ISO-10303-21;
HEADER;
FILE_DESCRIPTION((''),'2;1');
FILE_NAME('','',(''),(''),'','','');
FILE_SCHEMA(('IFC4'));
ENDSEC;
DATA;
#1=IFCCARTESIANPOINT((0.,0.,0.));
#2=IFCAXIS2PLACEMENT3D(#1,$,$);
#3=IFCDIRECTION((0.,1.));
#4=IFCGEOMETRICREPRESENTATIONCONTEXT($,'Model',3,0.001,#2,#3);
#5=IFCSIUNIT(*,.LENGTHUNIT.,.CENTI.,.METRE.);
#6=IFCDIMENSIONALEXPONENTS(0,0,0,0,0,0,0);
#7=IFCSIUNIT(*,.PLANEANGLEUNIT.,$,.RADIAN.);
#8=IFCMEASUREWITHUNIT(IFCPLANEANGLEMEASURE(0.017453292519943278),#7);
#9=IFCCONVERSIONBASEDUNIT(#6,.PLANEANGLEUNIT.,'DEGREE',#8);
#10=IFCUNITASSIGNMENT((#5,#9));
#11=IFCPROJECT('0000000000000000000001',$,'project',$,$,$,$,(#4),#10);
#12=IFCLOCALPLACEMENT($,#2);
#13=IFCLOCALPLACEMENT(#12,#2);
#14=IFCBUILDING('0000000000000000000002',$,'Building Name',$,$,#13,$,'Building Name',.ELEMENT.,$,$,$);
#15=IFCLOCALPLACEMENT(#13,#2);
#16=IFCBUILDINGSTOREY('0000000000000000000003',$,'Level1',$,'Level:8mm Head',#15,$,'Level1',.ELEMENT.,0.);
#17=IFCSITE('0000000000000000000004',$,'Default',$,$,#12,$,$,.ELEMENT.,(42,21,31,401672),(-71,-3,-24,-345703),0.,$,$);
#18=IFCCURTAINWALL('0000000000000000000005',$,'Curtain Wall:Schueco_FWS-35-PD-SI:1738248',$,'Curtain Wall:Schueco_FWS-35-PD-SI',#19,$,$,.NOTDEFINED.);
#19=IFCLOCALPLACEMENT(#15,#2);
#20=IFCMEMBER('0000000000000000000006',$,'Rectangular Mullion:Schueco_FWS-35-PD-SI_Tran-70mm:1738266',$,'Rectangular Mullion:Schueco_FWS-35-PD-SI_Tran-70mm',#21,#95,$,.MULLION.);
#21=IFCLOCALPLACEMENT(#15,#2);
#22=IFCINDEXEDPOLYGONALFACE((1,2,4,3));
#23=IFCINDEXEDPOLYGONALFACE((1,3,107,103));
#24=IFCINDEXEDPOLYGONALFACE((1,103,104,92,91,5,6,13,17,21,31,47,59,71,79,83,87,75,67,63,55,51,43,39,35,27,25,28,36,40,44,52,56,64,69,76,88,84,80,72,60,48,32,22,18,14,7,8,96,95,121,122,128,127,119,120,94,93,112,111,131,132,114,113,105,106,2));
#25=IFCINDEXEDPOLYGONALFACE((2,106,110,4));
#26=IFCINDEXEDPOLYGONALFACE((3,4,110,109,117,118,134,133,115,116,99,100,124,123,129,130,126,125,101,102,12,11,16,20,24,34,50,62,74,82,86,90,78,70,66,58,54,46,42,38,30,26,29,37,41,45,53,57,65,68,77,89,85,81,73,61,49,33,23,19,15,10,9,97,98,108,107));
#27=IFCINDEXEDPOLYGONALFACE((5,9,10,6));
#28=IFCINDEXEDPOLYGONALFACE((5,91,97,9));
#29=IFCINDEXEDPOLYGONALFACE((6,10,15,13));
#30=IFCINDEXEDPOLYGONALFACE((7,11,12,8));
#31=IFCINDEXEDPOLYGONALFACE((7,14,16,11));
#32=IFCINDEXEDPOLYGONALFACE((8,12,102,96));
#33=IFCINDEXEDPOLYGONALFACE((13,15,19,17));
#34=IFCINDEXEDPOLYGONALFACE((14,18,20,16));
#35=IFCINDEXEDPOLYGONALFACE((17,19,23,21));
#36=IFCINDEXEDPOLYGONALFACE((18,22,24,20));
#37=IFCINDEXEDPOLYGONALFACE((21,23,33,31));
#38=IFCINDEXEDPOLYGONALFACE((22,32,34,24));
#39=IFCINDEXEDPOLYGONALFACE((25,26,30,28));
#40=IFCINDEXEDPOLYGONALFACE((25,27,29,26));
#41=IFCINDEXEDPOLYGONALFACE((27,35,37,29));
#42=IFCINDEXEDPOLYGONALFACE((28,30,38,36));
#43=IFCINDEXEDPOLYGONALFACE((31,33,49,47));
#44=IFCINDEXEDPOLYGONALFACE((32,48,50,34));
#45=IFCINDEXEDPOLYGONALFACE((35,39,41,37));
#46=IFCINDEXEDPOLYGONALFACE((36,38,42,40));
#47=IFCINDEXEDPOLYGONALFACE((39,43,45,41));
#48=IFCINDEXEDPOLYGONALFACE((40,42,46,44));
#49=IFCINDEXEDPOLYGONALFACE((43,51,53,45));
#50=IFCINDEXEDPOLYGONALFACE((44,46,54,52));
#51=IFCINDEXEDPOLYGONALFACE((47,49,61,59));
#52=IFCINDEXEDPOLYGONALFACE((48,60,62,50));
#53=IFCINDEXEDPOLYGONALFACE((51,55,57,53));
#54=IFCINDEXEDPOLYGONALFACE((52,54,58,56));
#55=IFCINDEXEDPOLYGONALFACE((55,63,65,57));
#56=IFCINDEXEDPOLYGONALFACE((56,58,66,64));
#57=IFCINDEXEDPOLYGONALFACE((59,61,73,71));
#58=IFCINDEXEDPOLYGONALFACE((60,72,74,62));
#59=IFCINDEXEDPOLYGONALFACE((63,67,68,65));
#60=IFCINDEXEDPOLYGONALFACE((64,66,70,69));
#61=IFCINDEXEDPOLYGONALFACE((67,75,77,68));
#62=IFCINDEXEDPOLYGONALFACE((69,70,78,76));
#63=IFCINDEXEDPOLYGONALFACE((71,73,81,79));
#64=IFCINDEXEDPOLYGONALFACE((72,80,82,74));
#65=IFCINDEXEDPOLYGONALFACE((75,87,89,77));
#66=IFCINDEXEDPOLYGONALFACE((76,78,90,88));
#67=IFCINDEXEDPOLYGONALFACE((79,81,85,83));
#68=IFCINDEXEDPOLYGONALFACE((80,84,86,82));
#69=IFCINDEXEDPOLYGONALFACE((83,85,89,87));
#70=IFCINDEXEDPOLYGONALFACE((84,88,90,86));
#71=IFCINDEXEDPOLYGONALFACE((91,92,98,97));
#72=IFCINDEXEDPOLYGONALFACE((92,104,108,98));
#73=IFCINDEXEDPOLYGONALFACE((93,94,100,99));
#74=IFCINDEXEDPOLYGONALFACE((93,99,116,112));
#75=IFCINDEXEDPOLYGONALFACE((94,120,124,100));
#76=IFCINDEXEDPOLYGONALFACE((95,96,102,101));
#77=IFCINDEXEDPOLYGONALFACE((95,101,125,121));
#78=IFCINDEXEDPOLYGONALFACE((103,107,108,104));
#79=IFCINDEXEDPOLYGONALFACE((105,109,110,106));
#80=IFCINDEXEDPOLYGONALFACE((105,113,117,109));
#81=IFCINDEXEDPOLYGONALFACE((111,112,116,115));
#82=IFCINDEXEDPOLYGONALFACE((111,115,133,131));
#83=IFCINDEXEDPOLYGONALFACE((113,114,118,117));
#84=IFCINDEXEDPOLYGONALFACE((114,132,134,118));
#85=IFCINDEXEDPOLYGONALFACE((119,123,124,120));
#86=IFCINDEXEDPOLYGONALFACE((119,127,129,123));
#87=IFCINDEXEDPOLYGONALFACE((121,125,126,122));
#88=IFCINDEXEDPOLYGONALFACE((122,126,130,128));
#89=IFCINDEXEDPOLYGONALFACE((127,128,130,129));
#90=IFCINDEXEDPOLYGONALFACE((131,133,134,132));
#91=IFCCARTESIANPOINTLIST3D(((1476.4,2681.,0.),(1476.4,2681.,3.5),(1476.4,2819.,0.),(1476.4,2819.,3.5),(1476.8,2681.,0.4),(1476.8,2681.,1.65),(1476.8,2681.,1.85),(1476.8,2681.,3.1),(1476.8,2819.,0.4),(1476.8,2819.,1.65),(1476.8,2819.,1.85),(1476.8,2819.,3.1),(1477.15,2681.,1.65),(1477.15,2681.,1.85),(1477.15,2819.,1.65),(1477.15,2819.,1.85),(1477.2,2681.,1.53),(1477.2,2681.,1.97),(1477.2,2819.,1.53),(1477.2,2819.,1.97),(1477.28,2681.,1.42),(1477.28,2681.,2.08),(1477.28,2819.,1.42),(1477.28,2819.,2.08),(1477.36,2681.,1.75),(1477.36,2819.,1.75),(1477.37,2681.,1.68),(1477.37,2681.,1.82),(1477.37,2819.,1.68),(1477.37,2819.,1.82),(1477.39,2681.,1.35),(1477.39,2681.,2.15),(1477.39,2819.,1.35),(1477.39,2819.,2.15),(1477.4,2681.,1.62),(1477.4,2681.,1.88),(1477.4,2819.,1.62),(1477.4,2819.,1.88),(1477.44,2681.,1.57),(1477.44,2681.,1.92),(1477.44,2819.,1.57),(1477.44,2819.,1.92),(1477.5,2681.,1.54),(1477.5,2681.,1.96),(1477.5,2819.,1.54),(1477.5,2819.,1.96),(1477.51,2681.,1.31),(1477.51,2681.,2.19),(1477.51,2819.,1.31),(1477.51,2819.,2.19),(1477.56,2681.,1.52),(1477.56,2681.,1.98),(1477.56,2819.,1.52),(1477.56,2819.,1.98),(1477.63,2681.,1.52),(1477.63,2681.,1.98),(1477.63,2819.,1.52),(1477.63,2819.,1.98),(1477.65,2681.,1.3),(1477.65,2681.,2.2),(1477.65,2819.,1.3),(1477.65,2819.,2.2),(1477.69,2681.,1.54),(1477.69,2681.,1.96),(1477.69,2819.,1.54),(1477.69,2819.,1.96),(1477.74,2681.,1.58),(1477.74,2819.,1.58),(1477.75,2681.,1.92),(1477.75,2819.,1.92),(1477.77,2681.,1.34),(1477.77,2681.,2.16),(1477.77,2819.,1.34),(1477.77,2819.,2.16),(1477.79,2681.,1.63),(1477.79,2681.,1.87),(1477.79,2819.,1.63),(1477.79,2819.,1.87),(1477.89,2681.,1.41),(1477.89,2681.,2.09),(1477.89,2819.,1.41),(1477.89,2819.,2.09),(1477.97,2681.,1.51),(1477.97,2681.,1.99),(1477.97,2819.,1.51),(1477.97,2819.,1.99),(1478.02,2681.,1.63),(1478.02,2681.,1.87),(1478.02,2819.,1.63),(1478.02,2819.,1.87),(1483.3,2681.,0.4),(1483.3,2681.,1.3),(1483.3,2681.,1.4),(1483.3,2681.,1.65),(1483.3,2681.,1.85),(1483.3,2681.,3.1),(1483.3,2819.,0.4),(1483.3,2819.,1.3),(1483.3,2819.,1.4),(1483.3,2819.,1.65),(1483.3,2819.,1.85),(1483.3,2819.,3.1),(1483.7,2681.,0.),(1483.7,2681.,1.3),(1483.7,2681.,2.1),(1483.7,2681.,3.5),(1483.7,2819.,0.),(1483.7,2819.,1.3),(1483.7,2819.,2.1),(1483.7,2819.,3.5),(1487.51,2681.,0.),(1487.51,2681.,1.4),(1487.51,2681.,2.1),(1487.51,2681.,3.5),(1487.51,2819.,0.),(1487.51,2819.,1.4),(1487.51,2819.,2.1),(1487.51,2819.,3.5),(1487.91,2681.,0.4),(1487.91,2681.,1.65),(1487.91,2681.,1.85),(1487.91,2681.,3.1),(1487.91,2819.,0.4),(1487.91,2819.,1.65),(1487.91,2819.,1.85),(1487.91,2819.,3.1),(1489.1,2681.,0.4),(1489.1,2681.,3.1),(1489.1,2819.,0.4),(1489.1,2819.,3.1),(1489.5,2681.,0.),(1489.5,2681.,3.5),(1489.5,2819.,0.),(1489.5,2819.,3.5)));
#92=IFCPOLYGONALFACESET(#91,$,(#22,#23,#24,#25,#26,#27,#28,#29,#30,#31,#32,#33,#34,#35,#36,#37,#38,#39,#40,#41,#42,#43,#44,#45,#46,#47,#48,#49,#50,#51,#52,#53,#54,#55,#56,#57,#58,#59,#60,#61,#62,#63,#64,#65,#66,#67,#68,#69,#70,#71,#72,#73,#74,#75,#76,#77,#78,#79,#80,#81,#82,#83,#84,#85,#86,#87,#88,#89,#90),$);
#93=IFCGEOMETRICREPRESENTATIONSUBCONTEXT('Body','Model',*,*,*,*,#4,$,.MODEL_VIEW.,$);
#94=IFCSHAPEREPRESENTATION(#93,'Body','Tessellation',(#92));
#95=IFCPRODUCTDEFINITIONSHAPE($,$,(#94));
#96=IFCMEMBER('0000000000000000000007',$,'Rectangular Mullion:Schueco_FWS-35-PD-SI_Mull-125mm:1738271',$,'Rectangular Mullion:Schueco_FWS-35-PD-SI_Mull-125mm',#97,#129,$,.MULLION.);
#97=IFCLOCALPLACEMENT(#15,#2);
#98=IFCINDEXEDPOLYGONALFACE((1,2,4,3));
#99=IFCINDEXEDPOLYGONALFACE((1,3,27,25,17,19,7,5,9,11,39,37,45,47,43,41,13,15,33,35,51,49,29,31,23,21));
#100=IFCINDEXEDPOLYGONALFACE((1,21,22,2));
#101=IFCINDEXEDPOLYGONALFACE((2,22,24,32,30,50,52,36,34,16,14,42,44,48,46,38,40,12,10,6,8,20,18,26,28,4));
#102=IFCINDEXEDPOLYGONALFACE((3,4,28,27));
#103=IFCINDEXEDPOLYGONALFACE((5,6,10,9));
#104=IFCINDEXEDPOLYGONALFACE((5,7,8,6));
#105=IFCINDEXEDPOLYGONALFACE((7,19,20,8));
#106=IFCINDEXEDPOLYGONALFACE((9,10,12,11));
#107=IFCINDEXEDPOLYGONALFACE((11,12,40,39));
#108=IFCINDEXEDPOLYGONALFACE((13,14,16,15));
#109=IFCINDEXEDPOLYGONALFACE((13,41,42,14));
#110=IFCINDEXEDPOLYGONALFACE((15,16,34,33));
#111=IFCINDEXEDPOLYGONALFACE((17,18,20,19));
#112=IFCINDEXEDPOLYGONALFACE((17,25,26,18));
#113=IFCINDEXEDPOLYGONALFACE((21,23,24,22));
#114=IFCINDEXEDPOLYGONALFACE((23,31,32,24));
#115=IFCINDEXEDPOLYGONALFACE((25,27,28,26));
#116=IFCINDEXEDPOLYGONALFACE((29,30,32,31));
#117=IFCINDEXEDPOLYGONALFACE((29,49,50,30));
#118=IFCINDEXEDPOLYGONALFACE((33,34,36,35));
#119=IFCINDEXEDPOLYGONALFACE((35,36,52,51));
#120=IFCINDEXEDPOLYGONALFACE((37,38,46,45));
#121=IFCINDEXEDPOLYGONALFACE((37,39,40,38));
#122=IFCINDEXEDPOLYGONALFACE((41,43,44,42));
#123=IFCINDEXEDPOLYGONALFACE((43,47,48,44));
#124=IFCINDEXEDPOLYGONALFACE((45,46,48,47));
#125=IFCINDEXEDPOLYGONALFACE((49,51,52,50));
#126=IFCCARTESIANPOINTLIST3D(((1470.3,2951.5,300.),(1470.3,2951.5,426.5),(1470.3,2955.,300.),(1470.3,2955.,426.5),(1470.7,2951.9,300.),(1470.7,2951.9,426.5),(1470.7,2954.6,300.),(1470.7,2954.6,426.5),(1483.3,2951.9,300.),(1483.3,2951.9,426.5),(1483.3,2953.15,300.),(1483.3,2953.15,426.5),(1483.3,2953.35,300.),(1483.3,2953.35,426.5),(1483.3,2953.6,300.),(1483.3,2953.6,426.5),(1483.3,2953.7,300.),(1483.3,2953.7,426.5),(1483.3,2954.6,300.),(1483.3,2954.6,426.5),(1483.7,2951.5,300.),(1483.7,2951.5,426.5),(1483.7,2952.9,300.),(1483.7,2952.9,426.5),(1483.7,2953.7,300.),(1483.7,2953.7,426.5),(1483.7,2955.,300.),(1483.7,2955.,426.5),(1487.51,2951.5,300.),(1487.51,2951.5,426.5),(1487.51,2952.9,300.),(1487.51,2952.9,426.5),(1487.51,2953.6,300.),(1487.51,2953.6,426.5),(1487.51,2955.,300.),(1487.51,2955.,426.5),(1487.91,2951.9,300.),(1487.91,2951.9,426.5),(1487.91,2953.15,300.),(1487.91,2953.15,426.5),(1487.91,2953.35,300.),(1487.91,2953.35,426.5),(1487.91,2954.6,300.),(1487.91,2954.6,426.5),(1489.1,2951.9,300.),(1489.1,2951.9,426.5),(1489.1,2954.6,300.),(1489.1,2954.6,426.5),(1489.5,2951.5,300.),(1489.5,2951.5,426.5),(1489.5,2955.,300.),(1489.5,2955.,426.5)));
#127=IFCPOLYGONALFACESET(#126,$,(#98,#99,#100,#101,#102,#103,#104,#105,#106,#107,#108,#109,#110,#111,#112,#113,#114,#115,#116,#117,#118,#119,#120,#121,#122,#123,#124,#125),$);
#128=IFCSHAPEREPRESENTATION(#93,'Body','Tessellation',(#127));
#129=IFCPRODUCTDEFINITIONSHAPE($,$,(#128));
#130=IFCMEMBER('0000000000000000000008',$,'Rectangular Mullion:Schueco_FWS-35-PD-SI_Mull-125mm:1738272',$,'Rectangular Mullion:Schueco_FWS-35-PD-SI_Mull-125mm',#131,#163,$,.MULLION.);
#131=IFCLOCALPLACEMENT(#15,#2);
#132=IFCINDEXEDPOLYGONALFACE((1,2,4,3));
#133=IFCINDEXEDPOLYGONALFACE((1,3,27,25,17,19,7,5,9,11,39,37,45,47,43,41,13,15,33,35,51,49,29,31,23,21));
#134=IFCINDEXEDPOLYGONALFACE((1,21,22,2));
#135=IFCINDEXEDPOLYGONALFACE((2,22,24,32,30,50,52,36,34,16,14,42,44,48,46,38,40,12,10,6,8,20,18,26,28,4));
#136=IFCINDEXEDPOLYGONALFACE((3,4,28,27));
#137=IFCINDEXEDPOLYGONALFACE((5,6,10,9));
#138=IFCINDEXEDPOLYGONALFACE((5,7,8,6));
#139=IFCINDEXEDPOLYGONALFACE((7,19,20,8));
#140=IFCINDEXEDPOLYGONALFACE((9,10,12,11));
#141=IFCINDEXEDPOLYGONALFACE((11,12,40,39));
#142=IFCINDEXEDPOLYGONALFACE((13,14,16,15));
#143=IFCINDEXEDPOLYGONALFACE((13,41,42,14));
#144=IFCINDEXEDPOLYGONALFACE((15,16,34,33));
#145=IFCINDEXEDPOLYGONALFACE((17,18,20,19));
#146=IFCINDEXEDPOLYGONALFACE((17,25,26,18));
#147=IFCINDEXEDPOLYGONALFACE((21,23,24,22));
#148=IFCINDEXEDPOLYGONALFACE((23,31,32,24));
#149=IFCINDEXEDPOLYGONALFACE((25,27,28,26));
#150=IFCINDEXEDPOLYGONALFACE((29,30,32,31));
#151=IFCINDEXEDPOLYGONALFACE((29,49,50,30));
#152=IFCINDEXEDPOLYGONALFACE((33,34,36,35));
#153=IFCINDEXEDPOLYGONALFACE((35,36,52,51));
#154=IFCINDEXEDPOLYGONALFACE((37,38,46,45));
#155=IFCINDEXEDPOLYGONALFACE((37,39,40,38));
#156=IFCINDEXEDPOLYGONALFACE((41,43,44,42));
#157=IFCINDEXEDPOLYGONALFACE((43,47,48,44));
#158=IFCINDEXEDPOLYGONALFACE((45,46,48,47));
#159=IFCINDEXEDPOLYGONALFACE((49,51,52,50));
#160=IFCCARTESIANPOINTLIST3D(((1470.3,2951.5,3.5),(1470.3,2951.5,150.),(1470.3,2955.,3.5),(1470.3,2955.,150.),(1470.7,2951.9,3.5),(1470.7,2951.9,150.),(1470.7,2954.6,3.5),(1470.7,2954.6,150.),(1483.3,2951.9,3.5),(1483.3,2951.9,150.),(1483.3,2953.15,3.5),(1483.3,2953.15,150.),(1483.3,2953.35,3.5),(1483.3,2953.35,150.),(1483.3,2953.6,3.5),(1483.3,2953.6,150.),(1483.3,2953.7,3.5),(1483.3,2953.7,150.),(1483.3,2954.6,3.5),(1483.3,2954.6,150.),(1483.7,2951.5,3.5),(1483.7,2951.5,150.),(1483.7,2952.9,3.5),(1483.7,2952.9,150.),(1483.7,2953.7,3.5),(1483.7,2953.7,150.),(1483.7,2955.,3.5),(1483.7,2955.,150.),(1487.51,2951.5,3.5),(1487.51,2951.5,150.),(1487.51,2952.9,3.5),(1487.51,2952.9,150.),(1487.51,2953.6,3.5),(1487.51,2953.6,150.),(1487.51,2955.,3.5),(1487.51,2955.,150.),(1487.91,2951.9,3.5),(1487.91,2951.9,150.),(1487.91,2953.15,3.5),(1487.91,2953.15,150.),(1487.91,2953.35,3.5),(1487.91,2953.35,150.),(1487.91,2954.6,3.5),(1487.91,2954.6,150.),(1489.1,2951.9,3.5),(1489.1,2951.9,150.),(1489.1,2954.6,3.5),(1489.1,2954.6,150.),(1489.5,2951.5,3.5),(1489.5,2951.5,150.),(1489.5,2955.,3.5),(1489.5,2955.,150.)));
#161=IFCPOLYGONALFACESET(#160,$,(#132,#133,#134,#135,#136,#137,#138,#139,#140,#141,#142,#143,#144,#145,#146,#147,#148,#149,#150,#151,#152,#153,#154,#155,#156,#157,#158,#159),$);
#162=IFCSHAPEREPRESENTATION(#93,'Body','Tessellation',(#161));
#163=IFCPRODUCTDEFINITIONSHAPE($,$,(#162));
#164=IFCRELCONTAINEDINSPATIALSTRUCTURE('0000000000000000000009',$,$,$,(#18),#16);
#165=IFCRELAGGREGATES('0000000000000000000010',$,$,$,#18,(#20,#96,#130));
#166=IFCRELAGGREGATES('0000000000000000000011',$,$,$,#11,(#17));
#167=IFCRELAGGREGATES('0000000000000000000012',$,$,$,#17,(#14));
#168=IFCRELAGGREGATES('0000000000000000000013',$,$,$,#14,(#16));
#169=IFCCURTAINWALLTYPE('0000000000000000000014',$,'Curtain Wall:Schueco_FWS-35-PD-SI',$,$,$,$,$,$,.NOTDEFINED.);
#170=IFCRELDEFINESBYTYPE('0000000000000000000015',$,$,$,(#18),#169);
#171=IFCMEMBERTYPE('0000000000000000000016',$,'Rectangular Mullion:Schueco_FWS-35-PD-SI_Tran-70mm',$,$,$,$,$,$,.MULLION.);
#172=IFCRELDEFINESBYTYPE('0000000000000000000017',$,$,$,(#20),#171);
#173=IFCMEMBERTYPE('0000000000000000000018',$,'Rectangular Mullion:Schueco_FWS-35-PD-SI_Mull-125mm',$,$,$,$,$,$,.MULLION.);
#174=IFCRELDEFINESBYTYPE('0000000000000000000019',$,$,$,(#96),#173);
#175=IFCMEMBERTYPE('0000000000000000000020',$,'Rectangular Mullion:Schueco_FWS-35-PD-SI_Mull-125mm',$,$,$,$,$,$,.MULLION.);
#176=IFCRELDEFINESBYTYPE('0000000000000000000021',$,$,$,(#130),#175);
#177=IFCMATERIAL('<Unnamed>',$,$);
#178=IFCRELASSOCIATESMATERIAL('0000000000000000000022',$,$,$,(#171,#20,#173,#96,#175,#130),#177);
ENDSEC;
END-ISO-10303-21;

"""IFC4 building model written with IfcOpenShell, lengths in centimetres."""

from ifc_helpers import new_model, entity, si_unit, converted_unit, direction, frame, origin, place, context, subcontext, project, spatial, line, arc, indexed_curve, outline, extrude, source, transform, mapped, material, type_object, type_shapes, element, aggregate, save


model = new_model("IFC4")

# Units and contexts
model_context = context("Model", 3, precision=0.001, world=origin(), true_north=direction((0.0, 1.0)))
body_context = subcontext(model_context, "Body", "Model", "MODEL_VIEW")
ifc_project = project(units=[si_unit("LENGTHUNIT", "METRE", prefix="CENTI"), converted_unit("PLANEANGLEUNIT", "DEGREE", entity("IfcPlaneAngleMeasure", 0.017453292519943278), si_unit("PLANEANGLEUNIT", "RADIAN"), dimensions=[0, 0, 0, 0, 0, 0, 0])], contexts=[model_context])

# Site, building, storey
site_placement = place(None, origin())
site = spatial("IfcSite", under=ifc_project, at=site_placement, Name="Default", CompositionType="ELEMENT", RefLatitude=(42, 21, 31, 401672), RefLongitude=(-71, -3, -24, -345703), RefElevation=0.0)
building_placement = place(site_placement, origin())
building = spatial("IfcBuilding", under=site, at=building_placement, Name="Building Name", LongName="Building Name", CompositionType="ELEMENT")
storey_placement = place(building_placement, origin())
storey = spatial("IfcBuildingStorey", under=building, at=storey_placement, Name="Level1", ObjectType="Level:8mm Head", LongName="Level1", CompositionType="ELEMENT", Elevation=0.0)

# Curtain wall, members
curtain_wall_type = type_object("IfcCurtainWallType", Name="Curtain Wall:Schueco_FWS-35-PD-SI", PredefinedType="NOTDEFINED")
curtain_wall_placement = place(storey_placement, origin())
curtain_wall = element("IfcCurtainWall", 1, at=curtain_wall_placement, inside=storey, type_object=curtain_wall_type, Name="Curtain Wall:Schueco_FWS-35-PD-SI:1738248", ObjectType="Curtain Wall:Schueco_FWS-35-PD-SI", PredefinedType="NOTDEFINED")
ifc_material_1 = material(Name="<Unnamed>")
member_type_1 = type_object("IfcMemberType", Name="Rectangular Mullion:Schueco_FWS-35-PD-SI_Tran-70mm", PredefinedType="MULLION", material=ifc_material_1)
shared_shape_1 = source(origin(), body_context, "Body", "SweptSolid", [
    extrude(outline(indexed_curve([(-6.52, -1.78), (0.78, -1.78), (0.78, -0.38), (4.59, -0.38), (4.59, -1.78), (6.58, -1.78), (6.58, 1.72), (4.59, 1.72), (4.59, 0.32), (0.38, 0.32), (0.38, 0.07), (4.99, 0.07), (4.99, 1.32), (6.18, 1.32), (6.18, -1.38), (4.99, -1.38), (4.99, -0.13), (0.38, -0.13), (0.38, -1.38), (-6.12, -1.38), (-6.12, -0.13), (-5.77, -0.13), (-5.34, -0.48), (-4.9, -0.15), (-5.14, -0.15), (-5.56, -0.03), (-5.14, 0.09), (-4.9, 0.09), (-5.34, 0.42), (-5.77, 0.07), (-6.12, 0.07), (-6.12, 1.32), (0.38, 1.32), (0.38, 0.42), (0.78, 0.42), (0.78, 1.72), (-6.52, 1.72)], segments=[line(1, 2, 3, 4, 5, 6, 7, 8, 9, 10, 11, 12, 13, 14, 15, 16, 17, 18, 19, 20, 21, 22), arc(22, 23, 24), line(24, 25), arc(25, 26, 27), line(27, 28), arc(28, 29, 30), line(30, 31, 32, 33, 34, 35, 36, 37, 1)], self_intersect=False)), frame((-1.72, 4.58, -138.0), z_axis=(0.0, 0.0, 1.0), x_axis=(0.0, -1.0, 0.0)), (0.0, 0.0, 1.0), 138.0),
])
type_shapes(member_type_1, [shared_shape_1])
member_1_placement = place(curtain_wall_placement, frame((1487.5, 2819.0, 0.0), z_axis=(0.0, 1.0, 0.0), x_axis=(0.0, 0.0, -1.0)))
member_1 = element("IfcMember", 2, at=member_1_placement, type_object=member_type_1, material=ifc_material_1, Name="Rectangular Mullion:Schueco_FWS-35-PD-SI_Tran-70mm:1738266", ObjectType="Rectangular Mullion:Schueco_FWS-35-PD-SI_Tran-70mm", PredefinedType="MULLION", context=body_context, shape_type="MappedRepresentation", body=[
    mapped(shared_shape_1, transform((0.0, 0.0, 0.0), scale=1.0)),
])
member_type_2 = type_object("IfcMemberType", Name="Rectangular Mullion:Schueco_FWS-35-PD-SI_Mull-125mm", PredefinedType="MULLION", material=ifc_material_1)
shared_shape_2 = source(origin(), body_context, "Body", "SweptSolid", [
    extrude(outline(indexed_curve([(-13.37, -1.78), (0.03, -1.78), (0.03, -0.38), (3.84, -0.38), (3.84, -1.78), (5.83, -1.78), (5.83, 1.72), (3.84, 1.72), (3.84, 0.32), (-0.37, 0.32), (-0.37, 0.07), (4.24, 0.07), (4.24, 1.32), (5.43, 1.32), (5.43, -1.38), (4.24, -1.38), (4.24, -0.13), (-0.37, -0.13), (-0.37, -1.38), (-12.97, -1.38), (-12.97, 1.32), (-0.37, 1.32), (-0.37, 0.42), (0.03, 0.42), (0.03, 1.72), (-13.37, 1.72), (-13.37, -1.78)], self_intersect=False)), frame((-1.72, 3.83, -126.5), z_axis=(0.0, 0.0, 1.0), x_axis=(0.0, -1.0, 0.0)), (0.0, 0.0, 1.0), 126.5),
])
type_shapes(member_type_2, [shared_shape_2])
member_2_placement = place(curtain_wall_placement, frame((1487.5, 2955.0, 426.5), z_axis=(0.0, 0.0, 1.0), x_axis=(0.0, 1.0, 0.0)))
member_2 = element("IfcMember", 3, at=member_2_placement, type_object=member_type_2, material=ifc_material_1, Name="Rectangular Mullion:Schueco_FWS-35-PD-SI_Mull-125mm:1738271", ObjectType="Rectangular Mullion:Schueco_FWS-35-PD-SI_Mull-125mm", PredefinedType="MULLION", context=body_context, shape_type="MappedRepresentation", body=[
    mapped(shared_shape_2, transform((0.0, 0.0, 0.0), scale=1.0)),
])
member_type_3 = type_object("IfcMemberType", Name="Rectangular Mullion:Schueco_FWS-35-PD-SI_Mull-125mm", PredefinedType="MULLION", material=ifc_material_1)
shared_shape_3 = source(origin(), body_context, "Body", "SweptSolid", [
    extrude(outline(indexed_curve([(-13.37, -1.78), (0.03, -1.78), (0.03, -0.38), (3.84, -0.38), (3.84, -1.78), (5.83, -1.78), (5.83, 1.72), (3.84, 1.72), (3.84, 0.32), (-0.37, 0.32), (-0.37, 0.07), (4.24, 0.07), (4.24, 1.32), (5.43, 1.32), (5.43, -1.38), (4.24, -1.38), (4.24, -0.13), (-0.37, -0.13), (-0.37, -1.38), (-12.97, -1.38), (-12.97, 1.32), (-0.37, 1.32), (-0.37, 0.42), (0.03, 0.42), (0.03, 1.72), (-13.37, 1.72), (-13.37, -1.78)], self_intersect=False)), frame((-1.72, 3.83, -146.5), z_axis=(0.0, 0.0, 1.0), x_axis=(0.0, -1.0, 0.0)), (0.0, 0.0, 1.0), 146.5),
])
type_shapes(member_type_3, [shared_shape_3])
member_3_placement = place(curtain_wall_placement, frame((1487.5, 2955.0, 150.0), z_axis=(0.0, 0.0, 1.0), x_axis=(0.0, 1.0, 0.0)))
member_3 = element("IfcMember", 4, at=member_3_placement, type_object=member_type_3, material=ifc_material_1, Name="Rectangular Mullion:Schueco_FWS-35-PD-SI_Mull-125mm:1738272", ObjectType="Rectangular Mullion:Schueco_FWS-35-PD-SI_Mull-125mm", PredefinedType="MULLION", context=body_context, shape_type="MappedRepresentation", body=[
    mapped(shared_shape_3, transform((0.0, 0.0, 0.0), scale=1.0)),
])
aggregate(curtain_wall, [member_1, member_2, member_3])

save(model, "model.ifc")
